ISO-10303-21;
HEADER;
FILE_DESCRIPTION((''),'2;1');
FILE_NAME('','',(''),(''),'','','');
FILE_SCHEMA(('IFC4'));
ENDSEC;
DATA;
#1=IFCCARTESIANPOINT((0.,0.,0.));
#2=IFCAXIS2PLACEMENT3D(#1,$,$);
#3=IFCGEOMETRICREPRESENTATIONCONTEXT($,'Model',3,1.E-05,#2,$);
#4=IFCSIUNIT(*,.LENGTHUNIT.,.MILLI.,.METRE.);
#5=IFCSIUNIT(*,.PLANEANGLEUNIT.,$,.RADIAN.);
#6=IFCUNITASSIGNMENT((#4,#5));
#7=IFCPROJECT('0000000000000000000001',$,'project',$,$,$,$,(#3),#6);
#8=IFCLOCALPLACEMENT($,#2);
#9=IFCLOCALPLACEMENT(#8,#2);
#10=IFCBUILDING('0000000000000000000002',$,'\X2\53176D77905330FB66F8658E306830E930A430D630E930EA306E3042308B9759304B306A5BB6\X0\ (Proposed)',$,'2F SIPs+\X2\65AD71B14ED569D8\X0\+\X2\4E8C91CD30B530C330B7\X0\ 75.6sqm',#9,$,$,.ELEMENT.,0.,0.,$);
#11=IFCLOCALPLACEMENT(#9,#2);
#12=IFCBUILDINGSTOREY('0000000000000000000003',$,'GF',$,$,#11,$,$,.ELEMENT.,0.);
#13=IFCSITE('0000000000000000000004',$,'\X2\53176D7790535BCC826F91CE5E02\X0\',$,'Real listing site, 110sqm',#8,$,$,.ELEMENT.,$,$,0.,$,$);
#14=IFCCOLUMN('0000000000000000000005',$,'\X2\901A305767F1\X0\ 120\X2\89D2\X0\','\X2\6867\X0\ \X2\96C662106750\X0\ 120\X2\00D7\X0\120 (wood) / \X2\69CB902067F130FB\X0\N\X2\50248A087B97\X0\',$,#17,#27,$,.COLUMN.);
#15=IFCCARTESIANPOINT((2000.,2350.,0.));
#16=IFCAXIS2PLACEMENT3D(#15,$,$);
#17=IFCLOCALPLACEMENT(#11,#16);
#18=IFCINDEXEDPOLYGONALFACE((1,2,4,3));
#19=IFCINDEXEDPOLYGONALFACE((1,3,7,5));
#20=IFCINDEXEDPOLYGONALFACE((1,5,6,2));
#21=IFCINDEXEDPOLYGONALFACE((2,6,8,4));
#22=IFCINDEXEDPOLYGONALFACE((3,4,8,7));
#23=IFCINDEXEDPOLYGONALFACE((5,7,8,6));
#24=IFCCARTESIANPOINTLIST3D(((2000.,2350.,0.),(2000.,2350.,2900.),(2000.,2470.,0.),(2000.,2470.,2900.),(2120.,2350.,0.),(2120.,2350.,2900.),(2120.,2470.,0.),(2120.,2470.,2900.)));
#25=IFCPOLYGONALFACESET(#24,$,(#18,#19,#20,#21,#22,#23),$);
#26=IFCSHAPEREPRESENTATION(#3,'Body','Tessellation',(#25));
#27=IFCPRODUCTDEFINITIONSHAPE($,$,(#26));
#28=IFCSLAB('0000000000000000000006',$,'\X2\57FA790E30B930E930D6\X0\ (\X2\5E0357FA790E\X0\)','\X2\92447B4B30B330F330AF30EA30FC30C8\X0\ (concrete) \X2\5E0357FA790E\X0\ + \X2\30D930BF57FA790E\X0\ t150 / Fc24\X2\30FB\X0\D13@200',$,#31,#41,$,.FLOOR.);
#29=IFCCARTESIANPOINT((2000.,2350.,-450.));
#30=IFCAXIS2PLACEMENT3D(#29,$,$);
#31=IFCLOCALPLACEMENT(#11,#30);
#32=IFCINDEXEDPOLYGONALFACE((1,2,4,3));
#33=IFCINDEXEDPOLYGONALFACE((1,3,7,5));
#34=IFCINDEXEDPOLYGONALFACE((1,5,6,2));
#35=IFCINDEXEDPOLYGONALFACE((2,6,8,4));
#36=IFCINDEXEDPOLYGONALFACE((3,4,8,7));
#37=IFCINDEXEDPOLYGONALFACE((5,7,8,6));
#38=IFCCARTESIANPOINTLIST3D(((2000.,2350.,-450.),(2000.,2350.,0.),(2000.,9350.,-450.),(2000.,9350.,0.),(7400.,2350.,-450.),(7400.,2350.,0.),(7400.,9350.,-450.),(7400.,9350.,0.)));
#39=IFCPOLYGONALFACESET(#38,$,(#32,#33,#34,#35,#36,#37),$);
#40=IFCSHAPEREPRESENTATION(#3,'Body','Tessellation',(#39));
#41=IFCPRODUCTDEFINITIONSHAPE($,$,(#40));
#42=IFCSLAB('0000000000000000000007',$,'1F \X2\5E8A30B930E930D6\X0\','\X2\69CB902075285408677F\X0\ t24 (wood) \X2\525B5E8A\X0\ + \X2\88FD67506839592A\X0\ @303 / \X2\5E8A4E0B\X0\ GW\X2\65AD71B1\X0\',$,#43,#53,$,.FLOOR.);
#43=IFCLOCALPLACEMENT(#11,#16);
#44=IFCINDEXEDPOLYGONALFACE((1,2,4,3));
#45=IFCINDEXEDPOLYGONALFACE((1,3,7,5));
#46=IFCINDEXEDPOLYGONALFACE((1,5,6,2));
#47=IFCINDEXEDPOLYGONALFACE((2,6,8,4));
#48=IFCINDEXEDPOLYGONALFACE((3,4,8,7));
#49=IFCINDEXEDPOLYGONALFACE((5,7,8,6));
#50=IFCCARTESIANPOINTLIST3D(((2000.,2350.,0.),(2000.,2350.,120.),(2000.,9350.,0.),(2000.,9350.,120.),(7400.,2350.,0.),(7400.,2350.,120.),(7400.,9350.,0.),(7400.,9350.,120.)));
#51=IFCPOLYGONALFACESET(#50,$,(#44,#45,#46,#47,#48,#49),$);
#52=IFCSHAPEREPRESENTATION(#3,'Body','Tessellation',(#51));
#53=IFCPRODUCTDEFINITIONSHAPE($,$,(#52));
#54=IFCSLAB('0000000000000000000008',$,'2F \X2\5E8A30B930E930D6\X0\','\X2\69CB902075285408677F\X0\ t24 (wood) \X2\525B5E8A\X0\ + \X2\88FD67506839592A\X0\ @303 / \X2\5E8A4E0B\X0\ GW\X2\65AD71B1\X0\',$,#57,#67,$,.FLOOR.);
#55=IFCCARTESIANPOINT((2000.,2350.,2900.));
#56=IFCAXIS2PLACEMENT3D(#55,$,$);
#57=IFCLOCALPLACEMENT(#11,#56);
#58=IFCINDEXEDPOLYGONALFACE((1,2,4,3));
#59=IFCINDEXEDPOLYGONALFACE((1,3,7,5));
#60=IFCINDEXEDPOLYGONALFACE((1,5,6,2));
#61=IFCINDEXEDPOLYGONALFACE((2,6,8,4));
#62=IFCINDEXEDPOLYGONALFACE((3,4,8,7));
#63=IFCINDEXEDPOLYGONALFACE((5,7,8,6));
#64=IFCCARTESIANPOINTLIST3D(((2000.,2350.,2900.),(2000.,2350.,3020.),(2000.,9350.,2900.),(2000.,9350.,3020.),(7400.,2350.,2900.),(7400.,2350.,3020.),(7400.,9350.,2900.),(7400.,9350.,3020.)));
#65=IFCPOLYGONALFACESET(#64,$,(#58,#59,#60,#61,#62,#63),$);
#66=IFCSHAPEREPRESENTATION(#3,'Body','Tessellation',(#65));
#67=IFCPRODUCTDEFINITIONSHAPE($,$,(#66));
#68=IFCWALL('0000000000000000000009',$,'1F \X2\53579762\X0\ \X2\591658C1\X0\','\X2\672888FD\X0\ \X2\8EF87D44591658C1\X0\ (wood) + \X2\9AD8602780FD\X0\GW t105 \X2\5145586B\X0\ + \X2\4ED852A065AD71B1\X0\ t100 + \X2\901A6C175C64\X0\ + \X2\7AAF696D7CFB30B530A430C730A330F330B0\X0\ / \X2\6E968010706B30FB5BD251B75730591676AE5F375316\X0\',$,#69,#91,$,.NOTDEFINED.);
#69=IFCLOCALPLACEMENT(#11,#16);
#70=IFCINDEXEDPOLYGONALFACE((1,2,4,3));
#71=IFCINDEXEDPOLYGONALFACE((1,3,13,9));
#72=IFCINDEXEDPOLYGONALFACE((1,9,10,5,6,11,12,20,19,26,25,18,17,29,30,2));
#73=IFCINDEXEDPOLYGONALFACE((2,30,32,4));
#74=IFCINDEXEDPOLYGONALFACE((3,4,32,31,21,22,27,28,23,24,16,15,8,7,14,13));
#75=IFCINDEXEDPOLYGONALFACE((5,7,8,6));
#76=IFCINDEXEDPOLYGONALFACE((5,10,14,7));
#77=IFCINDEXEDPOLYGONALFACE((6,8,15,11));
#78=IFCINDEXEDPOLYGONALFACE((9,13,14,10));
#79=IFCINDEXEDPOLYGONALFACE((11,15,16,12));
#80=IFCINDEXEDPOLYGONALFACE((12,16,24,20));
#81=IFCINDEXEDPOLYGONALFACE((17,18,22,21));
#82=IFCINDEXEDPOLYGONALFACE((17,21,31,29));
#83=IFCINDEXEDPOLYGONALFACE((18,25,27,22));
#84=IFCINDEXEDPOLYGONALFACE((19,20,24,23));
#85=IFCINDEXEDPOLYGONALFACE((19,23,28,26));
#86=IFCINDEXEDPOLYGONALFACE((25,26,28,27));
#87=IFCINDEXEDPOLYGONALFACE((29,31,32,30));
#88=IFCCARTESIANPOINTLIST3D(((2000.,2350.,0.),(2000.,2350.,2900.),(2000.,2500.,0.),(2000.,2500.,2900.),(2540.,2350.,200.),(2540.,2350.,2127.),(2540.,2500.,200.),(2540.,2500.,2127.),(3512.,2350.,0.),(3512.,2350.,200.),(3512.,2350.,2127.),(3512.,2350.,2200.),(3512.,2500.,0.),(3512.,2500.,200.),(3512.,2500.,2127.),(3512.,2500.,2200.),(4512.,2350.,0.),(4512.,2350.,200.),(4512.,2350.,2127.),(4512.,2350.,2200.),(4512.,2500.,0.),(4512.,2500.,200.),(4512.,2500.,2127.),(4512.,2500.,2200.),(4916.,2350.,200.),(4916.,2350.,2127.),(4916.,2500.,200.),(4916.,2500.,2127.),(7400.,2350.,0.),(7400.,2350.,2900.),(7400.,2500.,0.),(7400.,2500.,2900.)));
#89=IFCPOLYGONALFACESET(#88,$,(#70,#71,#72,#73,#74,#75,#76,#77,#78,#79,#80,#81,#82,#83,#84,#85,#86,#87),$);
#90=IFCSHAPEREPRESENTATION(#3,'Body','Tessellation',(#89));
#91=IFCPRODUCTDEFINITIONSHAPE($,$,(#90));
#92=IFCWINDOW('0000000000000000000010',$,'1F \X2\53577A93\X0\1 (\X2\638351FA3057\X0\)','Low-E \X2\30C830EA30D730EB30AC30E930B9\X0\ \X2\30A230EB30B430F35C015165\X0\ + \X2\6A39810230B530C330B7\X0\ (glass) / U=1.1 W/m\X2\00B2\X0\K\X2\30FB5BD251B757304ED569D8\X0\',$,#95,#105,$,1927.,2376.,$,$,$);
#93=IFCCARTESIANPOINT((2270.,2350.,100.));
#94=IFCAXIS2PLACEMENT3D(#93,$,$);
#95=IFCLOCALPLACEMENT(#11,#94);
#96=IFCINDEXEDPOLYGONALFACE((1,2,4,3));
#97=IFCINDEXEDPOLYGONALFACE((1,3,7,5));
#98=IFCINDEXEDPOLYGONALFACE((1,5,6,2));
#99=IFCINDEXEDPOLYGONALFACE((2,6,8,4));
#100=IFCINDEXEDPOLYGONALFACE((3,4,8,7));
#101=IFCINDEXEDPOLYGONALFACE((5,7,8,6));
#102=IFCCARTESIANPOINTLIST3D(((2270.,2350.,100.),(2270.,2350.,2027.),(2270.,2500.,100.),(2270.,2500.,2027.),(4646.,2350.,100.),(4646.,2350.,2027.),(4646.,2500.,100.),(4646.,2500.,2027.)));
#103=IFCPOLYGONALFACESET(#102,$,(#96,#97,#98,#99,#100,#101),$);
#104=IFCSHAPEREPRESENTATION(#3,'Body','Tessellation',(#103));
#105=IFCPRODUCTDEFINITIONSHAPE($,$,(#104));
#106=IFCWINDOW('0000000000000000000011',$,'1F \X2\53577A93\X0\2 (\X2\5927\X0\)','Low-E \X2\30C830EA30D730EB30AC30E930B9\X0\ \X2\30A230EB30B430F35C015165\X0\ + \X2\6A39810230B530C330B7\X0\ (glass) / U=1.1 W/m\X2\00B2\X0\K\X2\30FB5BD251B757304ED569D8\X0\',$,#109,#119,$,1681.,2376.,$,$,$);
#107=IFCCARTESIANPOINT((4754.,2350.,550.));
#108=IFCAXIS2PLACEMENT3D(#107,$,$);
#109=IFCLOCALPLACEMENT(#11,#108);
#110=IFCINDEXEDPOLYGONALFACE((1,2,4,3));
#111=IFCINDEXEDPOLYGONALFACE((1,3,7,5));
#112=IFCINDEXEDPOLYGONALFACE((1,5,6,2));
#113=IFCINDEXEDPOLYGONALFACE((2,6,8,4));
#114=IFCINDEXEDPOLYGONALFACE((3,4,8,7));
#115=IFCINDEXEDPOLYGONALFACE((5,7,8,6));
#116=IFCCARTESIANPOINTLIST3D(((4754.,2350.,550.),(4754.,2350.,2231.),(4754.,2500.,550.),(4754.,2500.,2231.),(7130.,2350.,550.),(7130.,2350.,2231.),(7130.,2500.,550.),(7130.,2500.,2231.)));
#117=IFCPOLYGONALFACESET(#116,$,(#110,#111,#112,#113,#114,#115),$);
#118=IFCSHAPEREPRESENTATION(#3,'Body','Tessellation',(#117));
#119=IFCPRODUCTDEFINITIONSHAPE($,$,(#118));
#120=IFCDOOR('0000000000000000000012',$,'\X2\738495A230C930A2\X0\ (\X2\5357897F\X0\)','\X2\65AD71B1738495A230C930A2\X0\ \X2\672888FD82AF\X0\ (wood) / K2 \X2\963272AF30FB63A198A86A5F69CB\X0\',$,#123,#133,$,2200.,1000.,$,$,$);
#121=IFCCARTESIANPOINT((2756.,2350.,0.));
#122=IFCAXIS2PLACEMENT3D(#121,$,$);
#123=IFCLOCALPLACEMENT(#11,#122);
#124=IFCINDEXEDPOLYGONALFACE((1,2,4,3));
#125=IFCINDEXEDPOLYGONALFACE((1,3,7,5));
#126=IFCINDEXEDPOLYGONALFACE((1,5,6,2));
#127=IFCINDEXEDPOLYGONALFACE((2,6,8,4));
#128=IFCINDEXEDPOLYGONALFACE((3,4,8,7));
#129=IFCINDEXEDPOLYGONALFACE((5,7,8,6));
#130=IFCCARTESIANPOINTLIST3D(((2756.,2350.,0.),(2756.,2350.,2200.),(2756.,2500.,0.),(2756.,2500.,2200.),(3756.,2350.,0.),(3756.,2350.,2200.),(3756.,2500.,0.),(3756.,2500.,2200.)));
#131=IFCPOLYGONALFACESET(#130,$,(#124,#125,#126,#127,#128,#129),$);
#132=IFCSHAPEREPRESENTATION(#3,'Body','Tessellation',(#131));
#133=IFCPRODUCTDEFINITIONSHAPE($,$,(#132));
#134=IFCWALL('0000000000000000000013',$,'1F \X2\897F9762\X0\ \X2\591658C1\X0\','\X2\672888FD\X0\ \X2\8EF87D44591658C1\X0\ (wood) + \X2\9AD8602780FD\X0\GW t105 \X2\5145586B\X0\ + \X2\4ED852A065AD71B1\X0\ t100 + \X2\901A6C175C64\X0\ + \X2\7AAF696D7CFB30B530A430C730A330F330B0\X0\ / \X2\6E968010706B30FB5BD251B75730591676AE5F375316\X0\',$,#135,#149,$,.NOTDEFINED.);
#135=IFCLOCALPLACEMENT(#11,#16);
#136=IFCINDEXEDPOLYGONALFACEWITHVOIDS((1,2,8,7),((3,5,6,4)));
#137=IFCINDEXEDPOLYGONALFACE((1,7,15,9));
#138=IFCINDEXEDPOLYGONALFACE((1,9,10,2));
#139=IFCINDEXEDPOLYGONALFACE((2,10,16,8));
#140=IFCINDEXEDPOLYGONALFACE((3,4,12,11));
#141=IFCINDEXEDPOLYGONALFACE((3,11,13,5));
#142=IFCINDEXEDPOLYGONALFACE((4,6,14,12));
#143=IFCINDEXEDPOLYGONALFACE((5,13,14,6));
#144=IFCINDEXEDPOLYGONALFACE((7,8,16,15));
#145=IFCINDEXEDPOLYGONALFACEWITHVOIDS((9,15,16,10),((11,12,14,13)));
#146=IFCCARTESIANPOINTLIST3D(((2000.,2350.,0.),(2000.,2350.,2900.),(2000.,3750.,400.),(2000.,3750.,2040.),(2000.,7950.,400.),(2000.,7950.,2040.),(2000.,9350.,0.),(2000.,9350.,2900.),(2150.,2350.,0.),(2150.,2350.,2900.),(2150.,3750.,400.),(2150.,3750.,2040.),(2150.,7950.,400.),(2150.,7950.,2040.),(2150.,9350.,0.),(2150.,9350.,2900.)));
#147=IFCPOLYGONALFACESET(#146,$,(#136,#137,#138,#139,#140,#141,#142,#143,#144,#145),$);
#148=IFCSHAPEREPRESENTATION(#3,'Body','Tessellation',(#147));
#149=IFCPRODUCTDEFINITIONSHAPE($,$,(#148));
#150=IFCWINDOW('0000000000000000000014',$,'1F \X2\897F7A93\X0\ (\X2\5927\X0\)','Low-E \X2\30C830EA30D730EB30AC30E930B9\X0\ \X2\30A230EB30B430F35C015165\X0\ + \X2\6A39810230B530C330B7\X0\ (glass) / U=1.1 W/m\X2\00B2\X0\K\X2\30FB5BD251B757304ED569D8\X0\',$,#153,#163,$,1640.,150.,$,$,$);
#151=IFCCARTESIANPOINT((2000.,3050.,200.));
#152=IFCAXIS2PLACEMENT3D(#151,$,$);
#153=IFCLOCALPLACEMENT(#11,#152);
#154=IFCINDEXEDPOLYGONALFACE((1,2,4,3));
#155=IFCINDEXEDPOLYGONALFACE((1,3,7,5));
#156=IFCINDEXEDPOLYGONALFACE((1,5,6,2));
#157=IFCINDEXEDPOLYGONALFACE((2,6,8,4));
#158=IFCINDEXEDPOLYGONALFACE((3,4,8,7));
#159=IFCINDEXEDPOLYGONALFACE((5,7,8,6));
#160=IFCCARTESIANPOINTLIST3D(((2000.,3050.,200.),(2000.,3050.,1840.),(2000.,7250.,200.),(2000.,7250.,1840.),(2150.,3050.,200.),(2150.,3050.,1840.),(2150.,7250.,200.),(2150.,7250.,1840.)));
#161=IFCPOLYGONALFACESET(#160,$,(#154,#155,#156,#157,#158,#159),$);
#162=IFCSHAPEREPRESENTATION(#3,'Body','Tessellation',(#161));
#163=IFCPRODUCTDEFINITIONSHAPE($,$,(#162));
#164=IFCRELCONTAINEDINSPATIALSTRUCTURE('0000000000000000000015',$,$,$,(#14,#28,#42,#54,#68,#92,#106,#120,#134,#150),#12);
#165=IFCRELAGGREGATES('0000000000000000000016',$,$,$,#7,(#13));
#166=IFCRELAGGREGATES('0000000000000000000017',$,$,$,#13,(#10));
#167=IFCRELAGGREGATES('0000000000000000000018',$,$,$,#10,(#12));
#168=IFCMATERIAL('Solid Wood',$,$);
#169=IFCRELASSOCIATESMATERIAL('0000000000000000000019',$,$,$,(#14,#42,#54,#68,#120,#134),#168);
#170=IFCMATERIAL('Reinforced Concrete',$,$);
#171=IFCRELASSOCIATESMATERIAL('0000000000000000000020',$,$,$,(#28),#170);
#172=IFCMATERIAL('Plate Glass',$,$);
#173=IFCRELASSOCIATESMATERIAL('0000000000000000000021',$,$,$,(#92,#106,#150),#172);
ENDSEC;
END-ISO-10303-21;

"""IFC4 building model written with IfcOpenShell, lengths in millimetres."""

from ifc_helpers import new_model, si_unit, frame, frame_2d, origin, place, context, project, spatial, rectangle, extrude, material, element, fill, save


model = new_model("IFC4")

# Units and contexts
model_context = context("Model", 3, precision=1e-05, world=origin())
ifc_project = project(units=[si_unit("LENGTHUNIT", "METRE", prefix="MILLI"), si_unit("PLANEANGLEUNIT", "RADIAN")], contexts=[model_context])

# Site, building, storey
site_placement = place(None, origin())
site = spatial("IfcSite", under=ifc_project, at=site_placement, Name="北海道富良野市", ObjectType="Real listing site, 110sqm", CompositionType="ELEMENT", RefElevation=0.0)
building_placement = place(site_placement, origin())
building = spatial("IfcBuilding", under=site, at=building_placement, Name="北海道・書斎とライブラリのある静かな家 (Proposed)", ObjectType="2F SIPs+断熱仕様+二重サッシ 75.6sqm", CompositionType="ELEMENT", ElevationOfRefHeight=0.0, ElevationOfTerrain=0.0)
storey_placement = place(building_placement, origin())
storey = spatial("IfcBuildingStorey", under=building, at=storey_placement, Name="GF", CompositionType="ELEMENT", Elevation=0.0)

# Column
ifc_material_1 = material(Name="Solid Wood")
column_placement = place(storey_placement, frame((2000.0, 2350.0, 0.0)))
element("IfcColumn", 1, at=column_placement, inside=storey, material=ifc_material_1, Name="通し柱 120角", Description="桧 集成材 120×120 (wood) / 構造柱・N値計算", PredefinedType="COLUMN", context=model_context, shape_type="SweptSolid", body=[
    extrude(rectangle(XDim=120.0, YDim=120.0, at=frame_2d((60.0, 60.0))), frame((2000.0, 2350.0, 0.0)), (0.0, 0.0, 1.0), 2900.0),
])

# Slabs
ifc_material_2 = material(Name="Reinforced Concrete")
slab_1_placement = place(storey_placement, frame((2000.0, 2350.0, -450.0)))
element("IfcSlab", 2, at=slab_1_placement, inside=storey, material=ifc_material_2, Name="基礎スラブ (布基礎)", Description="鉄筋コンクリート (concrete) 布基礎 + ベタ基礎 t150 / Fc24・D13@200", PredefinedType="FLOOR", context=model_context, shape_type="SweptSolid", body=[
    extrude(rectangle(XDim=5400.0, YDim=7000.0, at=frame_2d((2700.0, 3500.0))), frame((2000.0, 2350.0, -450.0)), (0.0, 0.0, 1.0), 450.0),
])
slab_2_placement = place(storey_placement, frame((2000.0, 2350.0, 0.0)))
element("IfcSlab", 3, at=slab_2_placement, inside=storey, material=ifc_material_1, Name="1F 床スラブ", Description="構造用合板 t24 (wood) 剛床 + 製材根太 @303 / 床下 GW断熱", PredefinedType="FLOOR", context=model_context, shape_type="SweptSolid", body=[
    extrude(rectangle(XDim=5400.0, YDim=7000.0, at=frame_2d((2700.0, 3500.0))), frame((2000.0, 2350.0, 0.0)), (0.0, 0.0, 1.0), 120.0),
])
slab_3_placement = place(storey_placement, frame((2000.0, 2350.0, 2900.0)))
element("IfcSlab", 4, at=slab_3_placement, inside=storey, material=ifc_material_1, Name="2F 床スラブ", Description="構造用合板 t24 (wood) 剛床 + 製材根太 @303 / 床下 GW断熱", PredefinedType="FLOOR", context=model_context, shape_type="SweptSolid", body=[
    extrude(rectangle(XDim=5400.0, YDim=7000.0, at=frame_2d((2700.0, 3500.0))), frame((2000.0, 2350.0, 2900.0)), (0.0, 0.0, 1.0), 120.0),
])

# Wall, openings, windows, door
wall_1_placement = place(storey_placement, frame((2000.0, 2350.0, 0.0)))
wall_1 = element("IfcWall", 5, at=wall_1_placement, inside=storey, material=ifc_material_1, Name="1F 南面 外壁", Description="木製 軸組外壁 (wood) + 高性能GW t105 充填 + 付加断熱 t100 + 通気層 + 窯業系サイディング / 準耐火・寒冷地外皮強化", PredefinedType="NOTDEFINED", context=model_context, shape_type="SweptSolid", body=[
    extrude(rectangle(XDim=5400.0, YDim=150.0, at=frame_2d((2700.0, 75.0))), frame((2000.0, 2350.0, 0.0)), (0.0, 0.0, 1.0), 2900.0),
])
opening_1_placement = place(storey_placement, frame((2270.0, 2350.0, 100.0)))
opening_1 = element("IfcOpeningElement", 6, at=opening_1_placement, cuts=wall_1, PredefinedType="NOTDEFINED", context=model_context, shape_type="SweptSolid", body=[
    extrude(rectangle(XDim=2376.0, YDim=150.0, at=frame_2d((1188.0, 75.0))), frame((2270.0, 2350.0, 100.0)), (0.0, 0.0, 1.0), 1927.0),
])
opening_2_placement = place(storey_placement, frame((4754.0, 2350.0, 550.0)))
opening_2 = element("IfcOpeningElement", 7, at=opening_2_placement, cuts=wall_1, PredefinedType="NOTDEFINED", context=model_context, shape_type="SweptSolid", body=[
    extrude(rectangle(XDim=2376.0, YDim=150.0, at=frame_2d((1188.0, 75.0))), frame((4754.0, 2350.0, 550.0)), (0.0, 0.0, 1.0), 1681.0),
])
opening_3_placement = place(storey_placement, frame((2756.0, 2350.0, 0.0)))
opening_3 = element("IfcOpeningElement", 8, at=opening_3_placement, cuts=wall_1, PredefinedType="NOTDEFINED", context=model_context, shape_type="SweptSolid", body=[
    extrude(rectangle(XDim=1000.0, YDim=150.0, at=frame_2d((500.0, 75.0))), frame((2756.0, 2350.0, 0.0)), (0.0, 0.0, 1.0), 2200.0),
])
ifc_material_3 = material(Name="Plate Glass")
window_1_placement = place(storey_placement, frame((2270.0, 2350.0, 100.0)))
window_1 = element("IfcWindow", 9, at=window_1_placement, inside=storey, material=ifc_material_3, Name="1F 南窓1 (掃出し)", Description="Low-E トリプルガラス アルゴン封入 + 樹脂サッシ (glass) / U=1.1 W/m²K・寒冷地仕様", OverallHeight=1927.0, OverallWidth=2376.0, context=model_context, shape_type="SweptSolid", body=[
    extrude(rectangle(XDim=2376.0, YDim=150.0, at=frame_2d((1188.0, 75.0))), frame((2270.0, 2350.0, 100.0)), (0.0, 0.0, 1.0), 1927.0),
])
fill(opening_1, window_1)
window_2_placement = place(storey_placement, frame((4754.0, 2350.0, 550.0)))
window_2 = element("IfcWindow", 10, at=window_2_placement, inside=storey, material=ifc_material_3, Name="1F 南窓2 (大)", Description="Low-E トリプルガラス アルゴン封入 + 樹脂サッシ (glass) / U=1.1 W/m²K・寒冷地仕様", OverallHeight=1681.0, OverallWidth=2376.0, context=model_context, shape_type="SweptSolid", body=[
    extrude(rectangle(XDim=2376.0, YDim=150.0, at=frame_2d((1188.0, 75.0))), frame((4754.0, 2350.0, 550.0)), (0.0, 0.0, 1.0), 1681.0),
])
fill(opening_2, window_2)
door_placement = place(storey_placement, frame((2756.0, 2350.0, 0.0)))
door = element("IfcDoor", 11, at=door_placement, inside=storey, material=ifc_material_1, Name="玄関ドア (南西)", Description="断熱玄関ドア 木製芯 (wood) / K2 防犯・採風機構", OverallHeight=2200.0, OverallWidth=1000.0, context=model_context, shape_type="SweptSolid", body=[
    extrude(rectangle(XDim=1000.0, YDim=150.0, at=frame_2d((500.0, 75.0))), frame((2756.0, 2350.0, 0.0)), (0.0, 0.0, 1.0), 2200.0),
])
fill(opening_3, door)

# Wall, opening, window
wall_2_placement = place(storey_placement, frame((2000.0, 2350.0, 0.0)))
wall_2 = element("IfcWall", 12, at=wall_2_placement, inside=storey, material=ifc_material_1, Name="1F 西面 外壁", Description="木製 軸組外壁 (wood) + 高性能GW t105 充填 + 付加断熱 t100 + 通気層 + 窯業系サイディング / 準耐火・寒冷地外皮強化", PredefinedType="NOTDEFINED", context=model_context, shape_type="SweptSolid", body=[
    extrude(rectangle(XDim=150.0, YDim=7000.0, at=frame_2d((75.0, 3500.0))), frame((2000.0, 2350.0, 0.0)), (0.0, 0.0, 1.0), 2900.0),
])
opening_4_placement = place(storey_placement, frame((2000.0, 3050.0, 200.0)))
opening_4 = element("IfcOpeningElement", 13, at=opening_4_placement, cuts=wall_2, PredefinedType="NOTDEFINED", context=model_context, shape_type="SweptSolid", body=[
    extrude(rectangle(XDim=150.0, YDim=4200.0, at=frame_2d((75.0, 2100.0))), frame((2000.0, 3050.0, 200.0)), (0.0, 0.0, 1.0), 1640.0),
])
window_3_placement = place(storey_placement, frame((2000.0, 3050.0, 200.0)))
window_3 = element("IfcWindow", 14, at=window_3_placement, inside=storey, material=ifc_material_3, Name="1F 西窓 (大)", Description="Low-E トリプルガラス アルゴン封入 + 樹脂サッシ (glass) / U=1.1 W/m²K・寒冷地仕様", OverallHeight=1640.0, OverallWidth=150.0, context=model_context, shape_type="SweptSolid", body=[
    extrude(rectangle(XDim=150.0, YDim=4200.0, at=frame_2d((75.0, 2100.0))), frame((2000.0, 3050.0, 200.0)), (0.0, 0.0, 1.0), 1640.0),
])
fill(opening_4, window_3)

save(model, "model.ifc")
